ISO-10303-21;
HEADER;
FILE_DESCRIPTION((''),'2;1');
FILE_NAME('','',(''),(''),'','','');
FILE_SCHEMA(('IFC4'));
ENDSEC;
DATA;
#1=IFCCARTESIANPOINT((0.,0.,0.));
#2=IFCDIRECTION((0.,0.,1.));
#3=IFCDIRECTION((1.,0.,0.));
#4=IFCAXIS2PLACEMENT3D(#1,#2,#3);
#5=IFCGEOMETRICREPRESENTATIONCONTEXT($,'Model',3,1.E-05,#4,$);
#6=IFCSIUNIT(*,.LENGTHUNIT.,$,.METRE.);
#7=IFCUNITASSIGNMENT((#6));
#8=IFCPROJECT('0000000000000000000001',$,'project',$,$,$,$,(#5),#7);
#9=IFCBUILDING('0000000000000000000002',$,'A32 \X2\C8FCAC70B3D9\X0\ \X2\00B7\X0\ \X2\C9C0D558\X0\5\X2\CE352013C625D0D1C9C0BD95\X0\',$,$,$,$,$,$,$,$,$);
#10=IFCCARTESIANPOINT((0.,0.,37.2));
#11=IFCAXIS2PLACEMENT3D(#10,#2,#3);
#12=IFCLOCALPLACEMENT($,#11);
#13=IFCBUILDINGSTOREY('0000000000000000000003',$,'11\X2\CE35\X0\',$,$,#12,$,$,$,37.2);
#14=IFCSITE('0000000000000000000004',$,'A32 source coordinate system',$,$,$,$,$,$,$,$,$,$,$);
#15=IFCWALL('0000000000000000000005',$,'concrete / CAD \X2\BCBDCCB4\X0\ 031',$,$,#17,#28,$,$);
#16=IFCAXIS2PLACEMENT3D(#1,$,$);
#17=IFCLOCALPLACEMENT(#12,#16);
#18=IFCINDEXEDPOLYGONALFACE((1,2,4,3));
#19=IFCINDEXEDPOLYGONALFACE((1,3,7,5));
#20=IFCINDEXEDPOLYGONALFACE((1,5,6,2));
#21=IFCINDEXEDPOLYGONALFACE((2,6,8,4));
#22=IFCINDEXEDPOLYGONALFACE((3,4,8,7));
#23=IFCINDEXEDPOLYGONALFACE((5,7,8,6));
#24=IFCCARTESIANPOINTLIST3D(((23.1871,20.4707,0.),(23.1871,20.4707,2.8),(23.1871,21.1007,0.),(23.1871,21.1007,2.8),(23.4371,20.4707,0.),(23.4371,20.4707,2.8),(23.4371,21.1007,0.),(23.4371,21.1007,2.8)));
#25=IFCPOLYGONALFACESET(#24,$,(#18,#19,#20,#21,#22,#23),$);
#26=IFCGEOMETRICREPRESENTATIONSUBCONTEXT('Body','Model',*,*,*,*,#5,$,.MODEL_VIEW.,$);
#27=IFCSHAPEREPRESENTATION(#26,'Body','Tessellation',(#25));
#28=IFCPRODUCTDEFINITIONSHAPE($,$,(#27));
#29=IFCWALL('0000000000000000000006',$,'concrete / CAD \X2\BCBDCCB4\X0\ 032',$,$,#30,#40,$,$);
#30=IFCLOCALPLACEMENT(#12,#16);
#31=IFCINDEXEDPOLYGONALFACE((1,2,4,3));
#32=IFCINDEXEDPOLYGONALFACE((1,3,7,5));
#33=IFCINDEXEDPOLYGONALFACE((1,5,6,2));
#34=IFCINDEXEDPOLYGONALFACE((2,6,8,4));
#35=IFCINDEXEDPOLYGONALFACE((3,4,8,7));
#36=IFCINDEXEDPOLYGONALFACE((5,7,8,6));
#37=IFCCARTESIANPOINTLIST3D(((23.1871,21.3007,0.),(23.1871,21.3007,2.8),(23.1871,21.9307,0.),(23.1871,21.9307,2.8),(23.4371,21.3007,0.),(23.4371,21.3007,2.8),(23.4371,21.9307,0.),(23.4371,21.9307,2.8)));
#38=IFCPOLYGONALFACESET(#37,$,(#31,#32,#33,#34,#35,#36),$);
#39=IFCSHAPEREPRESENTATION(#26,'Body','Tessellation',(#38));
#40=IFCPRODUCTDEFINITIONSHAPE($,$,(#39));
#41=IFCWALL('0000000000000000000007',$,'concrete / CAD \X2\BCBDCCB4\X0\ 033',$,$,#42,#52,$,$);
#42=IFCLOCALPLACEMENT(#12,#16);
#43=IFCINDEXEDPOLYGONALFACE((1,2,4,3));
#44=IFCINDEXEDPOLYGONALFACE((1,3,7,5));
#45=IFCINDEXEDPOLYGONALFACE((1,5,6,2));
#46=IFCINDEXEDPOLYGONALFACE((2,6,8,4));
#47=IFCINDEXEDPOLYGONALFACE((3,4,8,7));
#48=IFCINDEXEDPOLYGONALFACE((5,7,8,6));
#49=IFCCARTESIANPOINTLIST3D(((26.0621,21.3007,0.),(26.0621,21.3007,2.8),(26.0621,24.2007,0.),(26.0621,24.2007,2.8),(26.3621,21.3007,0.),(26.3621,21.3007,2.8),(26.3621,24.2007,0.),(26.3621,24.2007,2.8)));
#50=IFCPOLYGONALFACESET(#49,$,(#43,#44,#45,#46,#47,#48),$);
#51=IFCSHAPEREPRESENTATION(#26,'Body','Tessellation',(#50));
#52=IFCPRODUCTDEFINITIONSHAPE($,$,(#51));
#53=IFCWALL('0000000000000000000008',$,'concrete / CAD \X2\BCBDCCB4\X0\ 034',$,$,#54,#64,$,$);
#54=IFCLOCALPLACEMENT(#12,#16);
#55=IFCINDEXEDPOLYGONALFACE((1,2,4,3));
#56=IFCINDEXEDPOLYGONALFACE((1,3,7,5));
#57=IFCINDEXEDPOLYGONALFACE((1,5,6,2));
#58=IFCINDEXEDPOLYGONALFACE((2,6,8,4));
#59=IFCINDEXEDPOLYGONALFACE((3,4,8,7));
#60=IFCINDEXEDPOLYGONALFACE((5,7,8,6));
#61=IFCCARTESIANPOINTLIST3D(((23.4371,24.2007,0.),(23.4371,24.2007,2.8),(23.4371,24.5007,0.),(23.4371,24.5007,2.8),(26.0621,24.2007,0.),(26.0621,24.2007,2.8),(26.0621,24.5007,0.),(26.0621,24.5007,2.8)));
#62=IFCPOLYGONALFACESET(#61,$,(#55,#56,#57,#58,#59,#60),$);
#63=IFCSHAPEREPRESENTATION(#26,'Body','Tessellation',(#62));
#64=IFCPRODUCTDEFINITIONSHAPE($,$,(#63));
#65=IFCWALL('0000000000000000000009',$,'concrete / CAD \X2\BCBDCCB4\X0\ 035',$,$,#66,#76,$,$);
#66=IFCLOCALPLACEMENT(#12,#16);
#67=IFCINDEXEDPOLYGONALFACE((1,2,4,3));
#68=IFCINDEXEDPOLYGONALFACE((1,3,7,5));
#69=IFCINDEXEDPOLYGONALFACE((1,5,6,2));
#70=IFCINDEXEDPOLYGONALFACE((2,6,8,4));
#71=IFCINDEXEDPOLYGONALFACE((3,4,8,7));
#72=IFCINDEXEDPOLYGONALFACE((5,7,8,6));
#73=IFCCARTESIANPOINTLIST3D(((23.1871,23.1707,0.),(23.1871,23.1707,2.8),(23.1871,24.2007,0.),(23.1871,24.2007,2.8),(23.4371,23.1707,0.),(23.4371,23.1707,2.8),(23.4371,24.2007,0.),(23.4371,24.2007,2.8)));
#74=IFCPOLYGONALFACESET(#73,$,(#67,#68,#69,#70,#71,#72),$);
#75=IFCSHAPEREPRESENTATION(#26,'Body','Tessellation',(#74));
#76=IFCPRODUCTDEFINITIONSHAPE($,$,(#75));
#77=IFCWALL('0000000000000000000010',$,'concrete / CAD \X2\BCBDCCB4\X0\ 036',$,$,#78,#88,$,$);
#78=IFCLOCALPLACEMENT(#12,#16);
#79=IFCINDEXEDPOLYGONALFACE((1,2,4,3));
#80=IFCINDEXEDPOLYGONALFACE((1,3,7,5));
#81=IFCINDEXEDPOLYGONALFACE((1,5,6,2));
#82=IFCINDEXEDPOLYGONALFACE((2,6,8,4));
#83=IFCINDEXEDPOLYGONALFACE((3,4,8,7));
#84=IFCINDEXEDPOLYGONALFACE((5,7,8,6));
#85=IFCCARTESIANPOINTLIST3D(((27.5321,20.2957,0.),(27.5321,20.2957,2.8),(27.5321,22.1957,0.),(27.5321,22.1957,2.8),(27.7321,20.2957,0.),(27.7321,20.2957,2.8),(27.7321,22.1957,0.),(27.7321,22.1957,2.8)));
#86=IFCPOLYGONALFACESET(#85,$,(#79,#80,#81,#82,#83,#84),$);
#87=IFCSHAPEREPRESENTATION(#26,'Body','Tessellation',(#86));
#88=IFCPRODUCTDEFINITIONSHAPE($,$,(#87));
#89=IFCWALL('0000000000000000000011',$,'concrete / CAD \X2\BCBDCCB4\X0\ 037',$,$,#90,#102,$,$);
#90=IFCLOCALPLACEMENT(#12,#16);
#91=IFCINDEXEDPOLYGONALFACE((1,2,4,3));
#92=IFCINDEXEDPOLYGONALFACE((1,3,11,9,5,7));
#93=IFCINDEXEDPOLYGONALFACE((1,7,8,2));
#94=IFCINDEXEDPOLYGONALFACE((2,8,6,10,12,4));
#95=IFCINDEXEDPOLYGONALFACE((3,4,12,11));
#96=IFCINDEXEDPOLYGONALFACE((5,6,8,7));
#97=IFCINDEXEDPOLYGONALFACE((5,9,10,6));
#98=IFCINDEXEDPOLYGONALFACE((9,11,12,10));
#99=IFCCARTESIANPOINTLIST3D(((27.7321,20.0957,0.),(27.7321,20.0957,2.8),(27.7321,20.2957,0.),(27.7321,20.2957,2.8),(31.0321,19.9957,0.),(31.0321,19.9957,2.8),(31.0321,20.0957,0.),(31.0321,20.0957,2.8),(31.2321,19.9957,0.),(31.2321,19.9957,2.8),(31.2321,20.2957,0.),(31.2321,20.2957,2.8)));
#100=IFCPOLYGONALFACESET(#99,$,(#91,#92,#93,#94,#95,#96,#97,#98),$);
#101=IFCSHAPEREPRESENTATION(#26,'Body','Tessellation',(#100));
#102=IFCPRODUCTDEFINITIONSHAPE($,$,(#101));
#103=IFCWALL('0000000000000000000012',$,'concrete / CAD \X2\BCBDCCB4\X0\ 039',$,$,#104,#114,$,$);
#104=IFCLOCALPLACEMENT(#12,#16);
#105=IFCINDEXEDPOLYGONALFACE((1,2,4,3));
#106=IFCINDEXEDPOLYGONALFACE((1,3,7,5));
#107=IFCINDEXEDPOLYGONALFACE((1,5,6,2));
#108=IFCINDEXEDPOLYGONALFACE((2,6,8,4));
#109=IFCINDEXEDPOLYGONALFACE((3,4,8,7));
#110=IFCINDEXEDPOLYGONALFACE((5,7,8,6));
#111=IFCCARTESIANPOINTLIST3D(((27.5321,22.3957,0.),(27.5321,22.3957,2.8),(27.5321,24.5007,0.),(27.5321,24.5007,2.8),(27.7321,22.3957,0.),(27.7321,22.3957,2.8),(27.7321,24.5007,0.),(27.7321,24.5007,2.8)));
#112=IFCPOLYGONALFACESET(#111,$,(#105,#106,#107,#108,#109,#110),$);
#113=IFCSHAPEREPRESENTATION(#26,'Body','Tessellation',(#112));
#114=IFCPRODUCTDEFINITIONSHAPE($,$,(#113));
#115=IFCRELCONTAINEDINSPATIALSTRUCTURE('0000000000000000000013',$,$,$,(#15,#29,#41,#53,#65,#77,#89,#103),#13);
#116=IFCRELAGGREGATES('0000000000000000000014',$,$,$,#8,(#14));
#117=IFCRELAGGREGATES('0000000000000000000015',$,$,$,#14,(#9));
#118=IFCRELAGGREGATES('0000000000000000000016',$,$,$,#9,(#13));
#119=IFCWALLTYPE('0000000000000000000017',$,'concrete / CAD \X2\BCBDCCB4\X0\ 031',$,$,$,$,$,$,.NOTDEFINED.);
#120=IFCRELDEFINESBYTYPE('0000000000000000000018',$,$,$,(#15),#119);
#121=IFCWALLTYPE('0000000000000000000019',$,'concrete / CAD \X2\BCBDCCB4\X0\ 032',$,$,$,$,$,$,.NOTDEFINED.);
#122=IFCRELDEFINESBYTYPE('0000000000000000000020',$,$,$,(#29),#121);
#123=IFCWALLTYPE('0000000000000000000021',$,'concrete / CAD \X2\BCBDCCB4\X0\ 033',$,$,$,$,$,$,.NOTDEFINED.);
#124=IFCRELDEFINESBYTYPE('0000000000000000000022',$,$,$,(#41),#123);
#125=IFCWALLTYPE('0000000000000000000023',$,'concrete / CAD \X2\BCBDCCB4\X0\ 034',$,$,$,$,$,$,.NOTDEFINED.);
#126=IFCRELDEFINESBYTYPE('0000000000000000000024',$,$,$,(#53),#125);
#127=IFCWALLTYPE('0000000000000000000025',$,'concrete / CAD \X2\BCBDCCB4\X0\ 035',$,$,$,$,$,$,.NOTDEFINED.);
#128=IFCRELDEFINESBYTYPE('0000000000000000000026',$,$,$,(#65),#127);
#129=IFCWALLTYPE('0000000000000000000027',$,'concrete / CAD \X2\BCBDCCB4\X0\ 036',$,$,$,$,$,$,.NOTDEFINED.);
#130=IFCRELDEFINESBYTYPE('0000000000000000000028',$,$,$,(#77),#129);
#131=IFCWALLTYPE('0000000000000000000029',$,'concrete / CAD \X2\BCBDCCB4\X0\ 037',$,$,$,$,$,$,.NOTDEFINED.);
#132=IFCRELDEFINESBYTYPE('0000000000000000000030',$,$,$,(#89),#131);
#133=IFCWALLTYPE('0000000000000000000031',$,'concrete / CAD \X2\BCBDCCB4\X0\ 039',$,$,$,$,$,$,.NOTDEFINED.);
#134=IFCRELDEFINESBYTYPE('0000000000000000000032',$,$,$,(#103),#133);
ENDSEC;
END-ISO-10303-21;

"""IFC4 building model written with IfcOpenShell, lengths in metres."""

from ifc_helpers import new_model, si_unit, frame, origin, origin_with_axes, place, context, subcontext, project, spatial, polyline, outline, extrude, source, transform, mapped, type_object, type_shapes, element, save


model = new_model("IFC4")

# Units and contexts
model_context = context("Model", 3, precision=1e-05, world=origin_with_axes())
body_context = subcontext(model_context, "Body", "Model", "MODEL_VIEW")
ifc_project = project(units=[si_unit("LENGTHUNIT", "METRE")], contexts=[model_context])

# Site, building, storey
site = spatial("IfcSite", under=ifc_project, Name="A32 source coordinate system")
building = spatial("IfcBuilding", under=site, Name="A32 주거동 · 지하5층–옥탑지붕")
storey_placement = place(None, frame((0.0, 0.0, 37.2), z_axis=(0.0, 0.0, 1.0), x_axis=(1.0, 0.0, 0.0)))
storey = spatial("IfcBuildingStorey", under=building, at=storey_placement, Name="11층", Elevation=37.2)

# Walls
wall_type_1 = type_object("IfcWallType", Name="concrete / CAD 벽체 031", PredefinedType="NOTDEFINED")
shared_shape_1 = source(origin(), body_context, "Body", "SweptSolid", [
    extrude(outline(polyline([(23.1871, 20.4707), (23.1871, 21.1007), (23.4371, 21.1007), (23.4371, 20.4707), (23.1871, 20.4707)])), origin(), (0.0, 0.0, 1.0), 2.8),
])
type_shapes(wall_type_1, [shared_shape_1])
wall_1_placement = place(storey_placement, origin_with_axes())
element("IfcWall", 1, at=wall_1_placement, inside=storey, type_object=wall_type_1, Name="concrete / CAD 벽체 031", context=body_context, shape_type="MappedRepresentation", body=[
    mapped(shared_shape_1, transform((0.0, 0.0, 0.0), scale=1.0)),
])
wall_type_2 = type_object("IfcWallType", Name="concrete / CAD 벽체 032", PredefinedType="NOTDEFINED")
shared_shape_2 = source(origin(), body_context, "Body", "SweptSolid", [
    extrude(outline(polyline([(23.4371, 21.9307), (23.4371, 21.3007), (23.1871, 21.3007), (23.1871, 21.9307), (23.4371, 21.9307)])), origin(), (0.0, 0.0, 1.0), 2.8),
])
type_shapes(wall_type_2, [shared_shape_2])
wall_2_placement = place(storey_placement, origin_with_axes())
element("IfcWall", 2, at=wall_2_placement, inside=storey, type_object=wall_type_2, Name="concrete / CAD 벽체 032", context=body_context, shape_type="MappedRepresentation", body=[
    mapped(shared_shape_2, transform((0.0, 0.0, 0.0), scale=1.0)),
])
wall_type_3 = type_object("IfcWallType", Name="concrete / CAD 벽체 033", PredefinedType="NOTDEFINED")
shared_shape_3 = source(origin(), body_context, "Body", "SweptSolid", [
    extrude(outline(polyline([(26.3621, 24.2007), (26.3621, 21.3007), (26.0621, 21.3007), (26.0621, 24.2007), (26.3621, 24.2007)])), origin(), (0.0, 0.0, 1.0), 2.8),
])
type_shapes(wall_type_3, [shared_shape_3])
wall_3_placement = place(storey_placement, origin_with_axes())
element("IfcWall", 3, at=wall_3_placement, inside=storey, type_object=wall_type_3, Name="concrete / CAD 벽체 033", context=body_context, shape_type="MappedRepresentation", body=[
    mapped(shared_shape_3, transform((0.0, 0.0, 0.0), scale=1.0)),
])
wall_type_4 = type_object("IfcWallType", Name="concrete / CAD 벽체 034", PredefinedType="NOTDEFINED")
shared_shape_4 = source(origin(), body_context, "Body", "SweptSolid", [
    extrude(outline(polyline([(23.4371, 24.5007), (26.0621, 24.5007), (26.0621, 24.2007), (23.4371, 24.2007), (23.4371, 24.5007)])), origin(), (0.0, 0.0, 1.0), 2.8),
])
type_shapes(wall_type_4, [shared_shape_4])
wall_4_placement = place(storey_placement, origin_with_axes())
element("IfcWall", 4, at=wall_4_placement, inside=storey, type_object=wall_type_4, Name="concrete / CAD 벽체 034", context=body_context, shape_type="MappedRepresentation", body=[
    mapped(shared_shape_4, transform((0.0, 0.0, 0.0), scale=1.0)),
])
wall_type_5 = type_object("IfcWallType", Name="concrete / CAD 벽체 035", PredefinedType="NOTDEFINED")
shared_shape_5 = source(origin(), body_context, "Body", "SweptSolid", [
    extrude(outline(polyline([(23.1871, 23.1707), (23.1871, 24.2007), (23.4371, 24.2007), (23.4371, 23.1707), (23.1871, 23.1707)])), origin(), (0.0, 0.0, 1.0), 2.8),
])
type_shapes(wall_type_5, [shared_shape_5])
wall_5_placement = place(storey_placement, origin_with_axes())
element("IfcWall", 5, at=wall_5_placement, inside=storey, type_object=wall_type_5, Name="concrete / CAD 벽체 035", context=body_context, shape_type="MappedRepresentation", body=[
    mapped(shared_shape_5, transform((0.0, 0.0, 0.0), scale=1.0)),
])
wall_type_6 = type_object("IfcWallType", Name="concrete / CAD 벽체 036", PredefinedType="NOTDEFINED")
shared_shape_6 = source(origin(), body_context, "Body", "SweptSolid", [
    extrude(outline(polyline([(27.7321, 22.1957), (27.7321, 20.2957), (27.5321, 20.2957), (27.5321, 22.1957), (27.7321, 22.1957)])), origin(), (0.0, 0.0, 1.0), 2.8),
])
type_shapes(wall_type_6, [shared_shape_6])
wall_6_placement = place(storey_placement, origin_with_axes())
element("IfcWall", 6, at=wall_6_placement, inside=storey, type_object=wall_type_6, Name="concrete / CAD 벽체 036", context=body_context, shape_type="MappedRepresentation", body=[
    mapped(shared_shape_6, transform((0.0, 0.0, 0.0), scale=1.0)),
])
wall_type_7 = type_object("IfcWallType", Name="concrete / CAD 벽체 037", PredefinedType="NOTDEFINED")
shared_shape_7 = source(origin(), body_context, "Body", "SweptSolid", [
    extrude(outline(polyline([(31.2321, 19.9957), (31.0321, 19.9957), (31.0321, 20.0957), (27.7321, 20.0957), (27.7321, 20.2957), (31.2321, 20.2957), (31.2321, 19.9957)])), origin(), (0.0, 0.0, 1.0), 2.8),
])
type_shapes(wall_type_7, [shared_shape_7])
wall_7_placement = place(storey_placement, origin_with_axes())
element("IfcWall", 7, at=wall_7_placement, inside=storey, type_object=wall_type_7, Name="concrete / CAD 벽체 037", context=body_context, shape_type="MappedRepresentation", body=[
    mapped(shared_shape_7, transform((0.0, 0.0, 0.0), scale=1.0)),
])
wall_type_8 = type_object("IfcWallType", Name="concrete / CAD 벽체 039", PredefinedType="NOTDEFINED")
shared_shape_8 = source(origin(), body_context, "Body", "SweptSolid", [
    extrude(outline(polyline([(27.7321, 24.5007), (27.7321, 22.3957), (27.5321, 22.3957), (27.5321, 24.5007), (27.7321, 24.5007)])), origin(), (0.0, 0.0, 1.0), 2.8),
])
type_shapes(wall_type_8, [shared_shape_8])
wall_8_placement = place(storey_placement, origin_with_axes())
element("IfcWall", 8, at=wall_8_placement, inside=storey, type_object=wall_type_8, Name="concrete / CAD 벽체 039", context=body_context, shape_type="MappedRepresentation", body=[
    mapped(shared_shape_8, transform((0.0, 0.0, 0.0), scale=1.0)),
])

save(model, "model.ifc")
